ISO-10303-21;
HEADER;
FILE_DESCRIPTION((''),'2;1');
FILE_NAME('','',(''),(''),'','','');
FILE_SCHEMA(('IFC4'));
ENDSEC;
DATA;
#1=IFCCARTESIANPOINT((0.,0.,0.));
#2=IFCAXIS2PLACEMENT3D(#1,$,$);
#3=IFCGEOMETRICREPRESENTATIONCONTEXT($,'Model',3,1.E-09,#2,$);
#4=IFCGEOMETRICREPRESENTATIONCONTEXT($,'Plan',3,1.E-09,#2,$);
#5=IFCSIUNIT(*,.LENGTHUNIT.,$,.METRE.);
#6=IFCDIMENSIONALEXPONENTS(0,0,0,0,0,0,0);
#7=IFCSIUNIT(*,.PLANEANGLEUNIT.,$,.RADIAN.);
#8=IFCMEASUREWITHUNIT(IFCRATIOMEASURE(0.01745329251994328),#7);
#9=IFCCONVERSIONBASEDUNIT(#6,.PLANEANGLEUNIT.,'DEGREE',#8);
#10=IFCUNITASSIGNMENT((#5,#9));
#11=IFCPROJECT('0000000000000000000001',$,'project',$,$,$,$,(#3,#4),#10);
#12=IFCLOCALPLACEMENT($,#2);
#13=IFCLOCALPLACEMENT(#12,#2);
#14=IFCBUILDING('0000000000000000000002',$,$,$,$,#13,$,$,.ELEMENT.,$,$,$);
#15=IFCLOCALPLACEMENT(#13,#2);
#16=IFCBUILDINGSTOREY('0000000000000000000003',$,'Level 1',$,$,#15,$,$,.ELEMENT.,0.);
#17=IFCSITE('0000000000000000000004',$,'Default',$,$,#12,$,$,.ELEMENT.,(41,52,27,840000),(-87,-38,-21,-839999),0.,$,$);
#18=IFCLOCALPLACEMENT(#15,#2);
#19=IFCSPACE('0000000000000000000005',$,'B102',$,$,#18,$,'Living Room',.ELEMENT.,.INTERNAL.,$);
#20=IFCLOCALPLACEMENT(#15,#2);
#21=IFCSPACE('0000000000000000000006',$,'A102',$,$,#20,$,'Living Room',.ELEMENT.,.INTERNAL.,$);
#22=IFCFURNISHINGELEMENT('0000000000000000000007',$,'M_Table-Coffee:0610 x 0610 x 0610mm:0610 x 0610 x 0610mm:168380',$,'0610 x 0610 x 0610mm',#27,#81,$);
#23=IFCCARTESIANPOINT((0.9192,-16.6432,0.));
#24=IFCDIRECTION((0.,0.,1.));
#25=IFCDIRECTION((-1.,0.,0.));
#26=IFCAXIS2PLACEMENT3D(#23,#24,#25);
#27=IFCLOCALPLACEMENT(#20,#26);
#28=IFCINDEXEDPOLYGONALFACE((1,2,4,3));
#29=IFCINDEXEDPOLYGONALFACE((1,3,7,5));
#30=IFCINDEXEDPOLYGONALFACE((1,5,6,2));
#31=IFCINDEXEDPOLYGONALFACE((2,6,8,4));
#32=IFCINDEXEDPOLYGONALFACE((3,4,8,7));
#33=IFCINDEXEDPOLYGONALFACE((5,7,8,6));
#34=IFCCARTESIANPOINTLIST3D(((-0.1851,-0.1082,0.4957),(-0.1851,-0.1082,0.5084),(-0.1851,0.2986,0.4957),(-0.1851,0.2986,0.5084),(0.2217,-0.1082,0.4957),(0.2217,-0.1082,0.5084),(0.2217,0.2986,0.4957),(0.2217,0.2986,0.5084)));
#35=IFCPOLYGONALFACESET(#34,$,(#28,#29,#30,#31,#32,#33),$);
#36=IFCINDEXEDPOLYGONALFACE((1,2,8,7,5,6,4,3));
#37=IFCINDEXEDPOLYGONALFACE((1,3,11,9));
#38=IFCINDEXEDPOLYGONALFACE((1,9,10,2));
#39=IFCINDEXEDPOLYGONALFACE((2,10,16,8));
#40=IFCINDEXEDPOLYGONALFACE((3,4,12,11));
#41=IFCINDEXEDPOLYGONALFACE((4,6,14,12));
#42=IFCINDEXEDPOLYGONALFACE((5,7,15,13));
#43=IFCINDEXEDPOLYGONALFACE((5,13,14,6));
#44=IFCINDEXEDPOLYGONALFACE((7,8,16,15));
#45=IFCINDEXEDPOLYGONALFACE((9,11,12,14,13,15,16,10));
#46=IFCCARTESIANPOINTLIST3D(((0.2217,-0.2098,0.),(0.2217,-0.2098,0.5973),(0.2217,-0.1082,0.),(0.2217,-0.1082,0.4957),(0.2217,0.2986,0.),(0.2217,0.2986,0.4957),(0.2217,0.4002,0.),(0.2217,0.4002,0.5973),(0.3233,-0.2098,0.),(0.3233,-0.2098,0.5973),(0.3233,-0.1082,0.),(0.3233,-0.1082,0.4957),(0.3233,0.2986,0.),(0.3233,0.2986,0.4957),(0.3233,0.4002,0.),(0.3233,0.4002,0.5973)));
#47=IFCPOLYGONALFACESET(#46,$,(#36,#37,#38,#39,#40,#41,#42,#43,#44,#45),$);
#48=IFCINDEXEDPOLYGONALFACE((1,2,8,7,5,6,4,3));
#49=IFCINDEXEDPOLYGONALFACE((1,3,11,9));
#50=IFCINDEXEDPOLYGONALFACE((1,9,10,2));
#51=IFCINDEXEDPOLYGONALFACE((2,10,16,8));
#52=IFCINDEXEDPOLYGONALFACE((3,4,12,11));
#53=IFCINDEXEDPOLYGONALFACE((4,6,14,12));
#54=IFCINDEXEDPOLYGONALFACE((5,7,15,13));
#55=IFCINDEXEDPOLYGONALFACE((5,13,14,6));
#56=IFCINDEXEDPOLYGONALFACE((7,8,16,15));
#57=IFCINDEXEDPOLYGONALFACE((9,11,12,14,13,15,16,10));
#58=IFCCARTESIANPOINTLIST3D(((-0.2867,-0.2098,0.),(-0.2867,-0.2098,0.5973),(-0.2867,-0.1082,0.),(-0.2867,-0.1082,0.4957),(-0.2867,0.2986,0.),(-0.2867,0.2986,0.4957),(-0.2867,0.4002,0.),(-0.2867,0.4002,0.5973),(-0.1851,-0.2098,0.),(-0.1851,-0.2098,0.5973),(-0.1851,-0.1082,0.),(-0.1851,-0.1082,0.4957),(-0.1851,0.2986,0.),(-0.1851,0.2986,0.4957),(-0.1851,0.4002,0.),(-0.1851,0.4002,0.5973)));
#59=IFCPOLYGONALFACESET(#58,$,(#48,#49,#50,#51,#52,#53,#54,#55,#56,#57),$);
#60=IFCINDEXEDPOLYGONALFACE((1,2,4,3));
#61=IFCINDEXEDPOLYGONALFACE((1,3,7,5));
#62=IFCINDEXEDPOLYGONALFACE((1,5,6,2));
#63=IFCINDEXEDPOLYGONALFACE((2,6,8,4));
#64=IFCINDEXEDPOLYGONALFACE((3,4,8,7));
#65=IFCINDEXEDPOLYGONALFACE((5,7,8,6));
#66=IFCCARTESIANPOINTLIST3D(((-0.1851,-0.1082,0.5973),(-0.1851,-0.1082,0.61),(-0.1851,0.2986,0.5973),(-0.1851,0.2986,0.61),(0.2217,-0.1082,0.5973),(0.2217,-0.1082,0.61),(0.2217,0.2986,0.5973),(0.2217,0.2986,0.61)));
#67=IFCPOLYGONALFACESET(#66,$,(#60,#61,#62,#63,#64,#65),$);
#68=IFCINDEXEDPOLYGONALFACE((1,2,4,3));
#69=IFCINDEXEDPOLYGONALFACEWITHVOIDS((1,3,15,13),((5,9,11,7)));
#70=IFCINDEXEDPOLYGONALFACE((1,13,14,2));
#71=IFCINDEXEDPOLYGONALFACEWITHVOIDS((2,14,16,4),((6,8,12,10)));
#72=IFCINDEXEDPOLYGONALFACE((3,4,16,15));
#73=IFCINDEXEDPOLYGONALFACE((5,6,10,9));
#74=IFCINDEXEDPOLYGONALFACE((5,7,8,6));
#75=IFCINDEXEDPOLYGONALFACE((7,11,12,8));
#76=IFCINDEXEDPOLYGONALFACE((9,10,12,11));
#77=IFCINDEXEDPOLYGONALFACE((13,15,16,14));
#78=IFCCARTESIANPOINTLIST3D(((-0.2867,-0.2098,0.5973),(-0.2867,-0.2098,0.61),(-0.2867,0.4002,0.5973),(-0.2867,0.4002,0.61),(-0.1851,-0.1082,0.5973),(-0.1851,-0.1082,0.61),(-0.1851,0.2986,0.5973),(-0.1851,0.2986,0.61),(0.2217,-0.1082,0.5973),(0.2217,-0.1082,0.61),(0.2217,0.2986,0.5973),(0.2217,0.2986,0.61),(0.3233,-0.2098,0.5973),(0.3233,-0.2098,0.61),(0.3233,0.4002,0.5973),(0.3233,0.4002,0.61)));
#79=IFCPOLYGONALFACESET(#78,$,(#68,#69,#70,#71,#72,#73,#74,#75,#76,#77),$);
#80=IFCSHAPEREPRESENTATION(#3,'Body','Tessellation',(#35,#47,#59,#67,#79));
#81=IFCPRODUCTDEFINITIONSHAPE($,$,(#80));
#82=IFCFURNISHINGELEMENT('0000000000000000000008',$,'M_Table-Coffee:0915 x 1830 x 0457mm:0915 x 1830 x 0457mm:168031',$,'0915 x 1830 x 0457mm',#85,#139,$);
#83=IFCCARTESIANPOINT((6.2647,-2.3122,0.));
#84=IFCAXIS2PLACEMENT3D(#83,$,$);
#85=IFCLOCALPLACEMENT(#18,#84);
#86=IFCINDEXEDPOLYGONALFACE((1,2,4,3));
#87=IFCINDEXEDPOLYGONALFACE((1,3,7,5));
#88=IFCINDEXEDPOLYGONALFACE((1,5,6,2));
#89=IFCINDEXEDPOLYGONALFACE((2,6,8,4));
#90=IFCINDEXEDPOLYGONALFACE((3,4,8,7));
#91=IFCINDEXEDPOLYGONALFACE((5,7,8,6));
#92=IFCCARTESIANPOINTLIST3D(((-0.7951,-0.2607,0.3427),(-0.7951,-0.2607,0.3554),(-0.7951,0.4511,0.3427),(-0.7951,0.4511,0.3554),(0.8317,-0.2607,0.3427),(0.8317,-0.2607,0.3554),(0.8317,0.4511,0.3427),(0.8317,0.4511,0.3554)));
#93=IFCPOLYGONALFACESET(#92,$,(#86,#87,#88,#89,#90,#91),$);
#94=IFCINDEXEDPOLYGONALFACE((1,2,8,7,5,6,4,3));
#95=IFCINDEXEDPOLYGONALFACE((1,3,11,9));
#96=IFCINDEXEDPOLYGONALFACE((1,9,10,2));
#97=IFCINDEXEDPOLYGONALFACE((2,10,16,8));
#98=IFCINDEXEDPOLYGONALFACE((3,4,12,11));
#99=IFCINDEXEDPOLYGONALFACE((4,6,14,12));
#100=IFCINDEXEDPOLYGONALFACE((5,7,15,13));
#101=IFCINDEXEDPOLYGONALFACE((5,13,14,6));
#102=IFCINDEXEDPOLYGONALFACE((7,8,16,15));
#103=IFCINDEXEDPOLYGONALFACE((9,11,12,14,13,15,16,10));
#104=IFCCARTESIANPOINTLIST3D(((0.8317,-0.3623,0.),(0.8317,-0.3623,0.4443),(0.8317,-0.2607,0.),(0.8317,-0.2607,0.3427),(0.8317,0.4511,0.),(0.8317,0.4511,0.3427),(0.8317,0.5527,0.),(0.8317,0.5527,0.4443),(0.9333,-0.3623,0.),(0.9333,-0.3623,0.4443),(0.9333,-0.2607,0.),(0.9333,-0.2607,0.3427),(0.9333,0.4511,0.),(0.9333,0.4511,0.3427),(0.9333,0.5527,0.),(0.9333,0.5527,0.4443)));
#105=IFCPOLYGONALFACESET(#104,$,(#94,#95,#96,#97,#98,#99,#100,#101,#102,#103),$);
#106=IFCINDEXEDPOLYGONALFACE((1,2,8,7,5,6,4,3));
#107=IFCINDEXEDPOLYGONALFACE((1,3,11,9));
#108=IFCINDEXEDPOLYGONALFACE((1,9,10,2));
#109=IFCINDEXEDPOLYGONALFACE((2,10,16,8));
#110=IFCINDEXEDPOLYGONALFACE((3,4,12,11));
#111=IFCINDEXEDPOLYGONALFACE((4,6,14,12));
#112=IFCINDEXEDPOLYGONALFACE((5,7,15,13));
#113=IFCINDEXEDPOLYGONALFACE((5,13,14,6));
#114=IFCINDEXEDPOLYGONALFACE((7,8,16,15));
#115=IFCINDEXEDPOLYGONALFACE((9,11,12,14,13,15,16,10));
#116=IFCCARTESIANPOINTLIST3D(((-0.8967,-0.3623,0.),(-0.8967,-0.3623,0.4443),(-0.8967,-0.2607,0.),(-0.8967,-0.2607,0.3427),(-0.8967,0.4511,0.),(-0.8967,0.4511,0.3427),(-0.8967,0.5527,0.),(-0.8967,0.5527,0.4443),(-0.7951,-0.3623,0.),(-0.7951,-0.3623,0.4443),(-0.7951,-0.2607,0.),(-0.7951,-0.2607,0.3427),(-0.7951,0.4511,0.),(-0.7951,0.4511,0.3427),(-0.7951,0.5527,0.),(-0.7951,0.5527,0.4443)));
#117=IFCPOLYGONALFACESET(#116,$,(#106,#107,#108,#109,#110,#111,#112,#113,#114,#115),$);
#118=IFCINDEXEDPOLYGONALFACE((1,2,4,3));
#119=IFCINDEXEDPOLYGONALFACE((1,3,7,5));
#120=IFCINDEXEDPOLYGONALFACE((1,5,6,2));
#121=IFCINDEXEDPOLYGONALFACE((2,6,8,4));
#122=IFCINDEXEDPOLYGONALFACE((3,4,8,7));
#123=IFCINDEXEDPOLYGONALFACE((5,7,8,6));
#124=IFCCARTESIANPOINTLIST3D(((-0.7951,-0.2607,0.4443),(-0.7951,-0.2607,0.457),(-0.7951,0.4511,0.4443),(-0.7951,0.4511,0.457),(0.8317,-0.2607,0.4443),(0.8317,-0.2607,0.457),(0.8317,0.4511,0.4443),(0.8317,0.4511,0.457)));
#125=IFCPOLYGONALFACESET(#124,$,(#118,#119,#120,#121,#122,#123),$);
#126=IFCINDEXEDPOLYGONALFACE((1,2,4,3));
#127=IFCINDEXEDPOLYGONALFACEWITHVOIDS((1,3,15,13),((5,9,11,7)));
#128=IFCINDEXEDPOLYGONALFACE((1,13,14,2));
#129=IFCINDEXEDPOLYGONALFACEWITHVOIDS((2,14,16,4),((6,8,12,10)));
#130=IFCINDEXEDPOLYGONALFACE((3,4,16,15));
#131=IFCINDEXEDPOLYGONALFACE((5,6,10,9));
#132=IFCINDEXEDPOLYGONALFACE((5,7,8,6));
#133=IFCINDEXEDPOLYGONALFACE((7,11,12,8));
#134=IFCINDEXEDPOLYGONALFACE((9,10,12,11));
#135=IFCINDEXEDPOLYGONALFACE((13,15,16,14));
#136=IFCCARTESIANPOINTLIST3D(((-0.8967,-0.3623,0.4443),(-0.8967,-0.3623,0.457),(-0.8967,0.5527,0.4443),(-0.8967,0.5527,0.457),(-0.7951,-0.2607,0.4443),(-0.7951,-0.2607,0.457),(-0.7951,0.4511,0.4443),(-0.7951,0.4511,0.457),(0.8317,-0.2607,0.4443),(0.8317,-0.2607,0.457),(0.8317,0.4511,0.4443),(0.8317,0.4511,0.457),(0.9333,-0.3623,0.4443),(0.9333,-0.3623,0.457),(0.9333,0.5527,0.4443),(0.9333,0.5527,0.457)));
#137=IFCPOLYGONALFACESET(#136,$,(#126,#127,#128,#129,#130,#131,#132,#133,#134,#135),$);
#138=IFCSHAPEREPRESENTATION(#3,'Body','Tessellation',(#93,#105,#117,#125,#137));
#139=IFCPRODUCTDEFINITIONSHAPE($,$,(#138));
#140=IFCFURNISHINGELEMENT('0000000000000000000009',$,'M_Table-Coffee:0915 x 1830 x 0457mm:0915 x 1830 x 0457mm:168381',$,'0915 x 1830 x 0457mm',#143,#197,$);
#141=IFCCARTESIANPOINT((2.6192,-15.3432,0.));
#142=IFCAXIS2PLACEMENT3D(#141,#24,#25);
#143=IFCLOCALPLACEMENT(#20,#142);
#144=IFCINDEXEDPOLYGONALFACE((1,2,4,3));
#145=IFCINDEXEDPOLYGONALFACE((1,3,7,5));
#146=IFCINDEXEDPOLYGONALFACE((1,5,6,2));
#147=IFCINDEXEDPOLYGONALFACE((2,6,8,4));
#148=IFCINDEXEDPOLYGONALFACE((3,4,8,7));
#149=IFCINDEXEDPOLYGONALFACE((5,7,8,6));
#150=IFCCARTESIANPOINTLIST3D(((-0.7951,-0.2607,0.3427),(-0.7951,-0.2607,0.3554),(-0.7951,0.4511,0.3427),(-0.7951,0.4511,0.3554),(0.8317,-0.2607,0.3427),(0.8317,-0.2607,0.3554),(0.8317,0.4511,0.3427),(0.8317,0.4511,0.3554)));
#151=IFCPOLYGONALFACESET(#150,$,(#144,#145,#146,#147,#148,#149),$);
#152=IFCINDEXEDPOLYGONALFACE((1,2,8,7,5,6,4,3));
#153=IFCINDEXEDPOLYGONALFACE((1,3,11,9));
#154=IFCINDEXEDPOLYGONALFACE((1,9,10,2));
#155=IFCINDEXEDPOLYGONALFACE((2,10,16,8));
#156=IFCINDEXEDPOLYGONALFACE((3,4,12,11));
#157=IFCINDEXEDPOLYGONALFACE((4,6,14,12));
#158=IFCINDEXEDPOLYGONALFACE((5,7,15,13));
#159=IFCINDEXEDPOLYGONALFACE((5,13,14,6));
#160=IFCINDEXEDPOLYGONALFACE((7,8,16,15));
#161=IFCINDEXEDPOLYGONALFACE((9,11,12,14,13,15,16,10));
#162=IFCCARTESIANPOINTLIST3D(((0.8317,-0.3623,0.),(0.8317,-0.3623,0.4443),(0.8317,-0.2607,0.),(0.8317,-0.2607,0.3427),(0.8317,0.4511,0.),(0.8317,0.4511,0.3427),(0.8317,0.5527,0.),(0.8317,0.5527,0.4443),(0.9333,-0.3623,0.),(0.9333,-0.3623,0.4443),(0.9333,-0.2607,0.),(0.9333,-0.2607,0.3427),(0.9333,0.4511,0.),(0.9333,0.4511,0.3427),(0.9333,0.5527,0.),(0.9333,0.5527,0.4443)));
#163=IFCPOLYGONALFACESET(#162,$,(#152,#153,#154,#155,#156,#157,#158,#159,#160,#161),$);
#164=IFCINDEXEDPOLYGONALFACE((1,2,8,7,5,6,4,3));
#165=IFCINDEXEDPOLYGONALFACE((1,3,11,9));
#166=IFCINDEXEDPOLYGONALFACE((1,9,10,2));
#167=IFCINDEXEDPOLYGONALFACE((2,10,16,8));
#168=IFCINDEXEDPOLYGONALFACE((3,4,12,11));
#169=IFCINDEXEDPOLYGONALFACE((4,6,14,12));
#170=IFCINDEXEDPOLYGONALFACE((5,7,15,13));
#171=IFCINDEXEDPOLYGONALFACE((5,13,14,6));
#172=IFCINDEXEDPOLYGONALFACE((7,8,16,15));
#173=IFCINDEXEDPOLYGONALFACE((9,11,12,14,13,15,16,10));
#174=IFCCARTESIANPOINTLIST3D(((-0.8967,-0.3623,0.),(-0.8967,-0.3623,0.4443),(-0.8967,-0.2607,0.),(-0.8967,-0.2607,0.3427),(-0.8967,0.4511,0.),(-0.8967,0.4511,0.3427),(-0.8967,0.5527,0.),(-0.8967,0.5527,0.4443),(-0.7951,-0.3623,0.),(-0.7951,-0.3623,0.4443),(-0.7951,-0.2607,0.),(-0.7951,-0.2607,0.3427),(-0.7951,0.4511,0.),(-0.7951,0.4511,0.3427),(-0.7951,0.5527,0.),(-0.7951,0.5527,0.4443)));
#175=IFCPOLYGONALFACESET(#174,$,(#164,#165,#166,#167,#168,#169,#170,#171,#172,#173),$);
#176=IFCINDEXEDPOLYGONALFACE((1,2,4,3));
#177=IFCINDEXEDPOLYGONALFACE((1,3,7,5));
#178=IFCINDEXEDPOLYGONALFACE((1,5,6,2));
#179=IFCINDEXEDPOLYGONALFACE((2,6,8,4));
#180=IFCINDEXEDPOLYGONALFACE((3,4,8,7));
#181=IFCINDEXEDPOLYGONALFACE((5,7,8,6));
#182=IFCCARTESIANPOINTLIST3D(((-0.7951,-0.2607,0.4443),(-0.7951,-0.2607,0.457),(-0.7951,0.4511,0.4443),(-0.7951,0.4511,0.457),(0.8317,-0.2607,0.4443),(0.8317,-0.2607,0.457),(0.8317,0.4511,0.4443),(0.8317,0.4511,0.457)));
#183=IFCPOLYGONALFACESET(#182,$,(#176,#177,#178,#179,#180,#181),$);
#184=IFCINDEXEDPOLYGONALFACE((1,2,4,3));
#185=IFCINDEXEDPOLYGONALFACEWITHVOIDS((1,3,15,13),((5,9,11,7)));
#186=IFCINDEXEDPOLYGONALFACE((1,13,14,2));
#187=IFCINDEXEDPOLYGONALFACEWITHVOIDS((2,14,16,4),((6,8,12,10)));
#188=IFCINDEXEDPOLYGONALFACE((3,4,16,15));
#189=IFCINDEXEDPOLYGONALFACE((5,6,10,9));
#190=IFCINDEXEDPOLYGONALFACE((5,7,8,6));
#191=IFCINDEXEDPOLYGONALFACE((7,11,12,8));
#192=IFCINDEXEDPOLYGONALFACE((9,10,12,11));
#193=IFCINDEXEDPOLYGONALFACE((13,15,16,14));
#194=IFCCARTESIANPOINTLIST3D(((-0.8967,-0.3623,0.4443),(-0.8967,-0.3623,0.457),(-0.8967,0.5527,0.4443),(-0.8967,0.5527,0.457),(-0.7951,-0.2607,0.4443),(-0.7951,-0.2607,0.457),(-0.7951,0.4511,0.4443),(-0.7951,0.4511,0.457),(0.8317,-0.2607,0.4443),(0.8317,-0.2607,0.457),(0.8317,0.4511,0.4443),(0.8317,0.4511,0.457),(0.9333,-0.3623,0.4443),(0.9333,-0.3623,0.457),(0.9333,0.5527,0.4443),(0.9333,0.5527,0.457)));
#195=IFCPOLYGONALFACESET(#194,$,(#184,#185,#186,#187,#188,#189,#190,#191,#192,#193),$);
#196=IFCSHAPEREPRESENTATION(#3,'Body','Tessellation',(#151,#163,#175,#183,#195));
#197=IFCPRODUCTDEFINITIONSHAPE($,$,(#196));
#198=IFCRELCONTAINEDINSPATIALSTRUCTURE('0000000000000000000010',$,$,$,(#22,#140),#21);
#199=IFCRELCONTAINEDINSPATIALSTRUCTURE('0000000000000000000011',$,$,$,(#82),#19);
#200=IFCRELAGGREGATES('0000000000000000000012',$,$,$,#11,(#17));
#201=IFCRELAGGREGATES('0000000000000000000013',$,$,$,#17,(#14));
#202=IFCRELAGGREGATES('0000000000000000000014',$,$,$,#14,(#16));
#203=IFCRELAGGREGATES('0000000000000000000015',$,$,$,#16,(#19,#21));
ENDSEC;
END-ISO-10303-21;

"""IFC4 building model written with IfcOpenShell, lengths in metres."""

from ifc_helpers import new_model, entity, si_unit, converted_unit, frame, origin, origin_2d_with_axis, place, context, project, spatial, polyline, rectangle, outline, extrude, source, transform, mapped, element, save


model = new_model("IFC4")

# Units and contexts
model_context = context("Model", 3, precision=1e-09, world=origin())
plan_context = context("Plan", 3, precision=1e-09, world=origin())
ifc_project = project(units=[si_unit("LENGTHUNIT", "METRE"), converted_unit("PLANEANGLEUNIT", "DEGREE", entity("IfcRatioMeasure", 0.01745329251994328), si_unit("PLANEANGLEUNIT", "RADIAN"), dimensions=[0, 0, 0, 0, 0, 0, 0])], contexts=[model_context, plan_context])

# Site, building, storey
site_placement = place(None, origin())
site = spatial("IfcSite", under=ifc_project, at=site_placement, Name="Default", CompositionType="ELEMENT", RefLatitude=(41, 52, 27, 840000), RefLongitude=(-87, -38, -21, -839999), RefElevation=0.0)
building_placement = place(site_placement, origin())
building = spatial("IfcBuilding", under=site, at=building_placement, CompositionType="ELEMENT")
storey_placement = place(building_placement, origin())
storey = spatial("IfcBuildingStorey", under=building, at=storey_placement, Name="Level 1", CompositionType="ELEMENT", Elevation=0.0)

# Shared definitions
space_1_placement = place(storey_placement, origin())
space_1 = spatial("IfcSpace", under=storey, at=space_1_placement, Name="B102", LongName="Living Room", CompositionType="ELEMENT", PredefinedType="INTERNAL")

# Shared definitions
shared_shape_1 = source(origin(), model_context, "Body", "SweptSolid", [
    extrude(rectangle(XDim=0.4068, YDim=0.4068, at=origin_2d_with_axis()), frame((0.0183, 0.0952, 0.4957), z_axis=(0.0, 0.0, 1.0), x_axis=(-1.0, 0.0, 0.0)), (0.0, 0.0, 1.0), 0.0127),
    extrude(outline(polyline([(-0.2732, -0.305), (0.324, -0.305), (0.324, 0.305), (-0.2732, 0.305), (-0.2732, 0.2034), (0.2225, 0.2034), (0.2225, -0.2034), (-0.2732, -0.2034), (-0.2732, -0.305)])), frame((0.2217, 0.0952, 0.2732), z_axis=(1.0, 0.0, 0.0), x_axis=(0.0, 0.0, 1.0)), (0.0, 0.0, 1.0), 0.1016),
    extrude(outline(polyline([(-0.305, -0.3241), (0.305, -0.3241), (0.305, 0.2733), (0.2034, 0.2733), (0.2034, -0.2224), (-0.2034, -0.2224), (-0.2034, 0.2733), (-0.305, 0.2733), (-0.305, -0.3241)])), frame((-0.2867, 0.0952, 0.2733), z_axis=(1.0, 0.0, 0.0), x_axis=(0.0, -1.0, 0.0)), (0.0, 0.0, 1.0), 0.1016),
    extrude(rectangle(XDim=0.4068, YDim=0.4068, at=origin_2d_with_axis()), frame((0.0183, 0.0952, 0.5973), z_axis=(0.0, 0.0, 1.0), x_axis=(-1.0, 0.0, 0.0)), (0.0, 0.0, 1.0), 0.0127),
    extrude(outline(polyline([(-0.305, -0.305), (0.305, -0.305), (0.305, 0.305), (-0.305, 0.305), (-0.305, -0.305)]), holes=[polyline([(-0.2034, -0.2034), (-0.2034, 0.2034), (0.2034, 0.2034), (0.2034, -0.2034), (-0.2034, -0.2034)])]), frame((0.0183, 0.0952, 0.5973), z_axis=(0.0, 0.0, 1.0), x_axis=(-1.0, 0.0, 0.0)), (0.0, 0.0, 1.0), 0.0127),
])

# Shared definitions
space_2_placement = place(storey_placement, origin())
space_2 = spatial("IfcSpace", under=storey, at=space_2_placement, Name="A102", LongName="Living Room", CompositionType="ELEMENT", PredefinedType="INTERNAL")

# Furnishing elements
for number, where, z_axis, x_axis, name in (
    (1, (0.9192, -16.6432, 0.0), (0.0, 0.0, 1.0), (-1.0, 0.0, 0.0), "M_Table-Coffee:0610 x 0610 x 0610mm:0610 x 0610 x 0610mm:168380"),
):
    element("IfcFurnishingElement", number, at=place(space_2_placement, frame(where, z_axis=z_axis, x_axis=x_axis)), inside=space_2, Name=name, ObjectType="0610 x 0610 x 0610mm", context=model_context, shape_type="MappedRepresentation", body=[
        mapped(shared_shape_1, transform((0.0, 0.0, 0.0), scale=1.0)),
    ])
shared_shape_2 = source(origin(), model_context, "Body", "SweptSolid", [
    extrude(rectangle(XDim=1.6268, YDim=0.7118, at=origin_2d_with_axis()), frame((0.0183, 0.0952, 0.3427), z_axis=(0.0, 0.0, 1.0), x_axis=(-1.0, 0.0, 0.0)), (0.0, 0.0, 1.0), 0.0127),
    extrude(outline(polyline([(-0.1967, -0.4575), (0.2475, -0.4575), (0.2475, 0.4575), (-0.1967, 0.4575), (-0.1967, 0.3559), (0.146, 0.3559), (0.146, -0.3559), (-0.1967, -0.3559), (-0.1967, -0.4575)])), frame((0.8317, 0.0952, 0.1967), z_axis=(1.0, 0.0, 0.0), x_axis=(0.0, 0.0, 1.0)), (0.0, 0.0, 1.0), 0.1016),
    extrude(outline(polyline([(-0.4575, -0.2476), (0.4575, -0.2476), (0.4575, 0.1968), (0.3559, 0.1968), (0.3559, -0.1459), (-0.3559, -0.1459), (-0.3559, 0.1968), (-0.4575, 0.1968), (-0.4575, -0.2476)])), frame((-0.8967, 0.0952, 0.1968), z_axis=(1.0, 0.0, 0.0), x_axis=(0.0, -1.0, 0.0)), (0.0, 0.0, 1.0), 0.1016),
    extrude(rectangle(XDim=1.6268, YDim=0.7118, at=origin_2d_with_axis()), frame((0.0183, 0.0952, 0.4443), z_axis=(0.0, 0.0, 1.0), x_axis=(-1.0, 0.0, 0.0)), (0.0, 0.0, 1.0), 0.0127),
    extrude(outline(polyline([(-0.915, -0.4575), (0.915, -0.4575), (0.915, 0.4575), (-0.915, 0.4575), (-0.915, -0.4575)]), holes=[polyline([(-0.8134, -0.3559), (-0.8134, 0.3559), (0.8134, 0.3559), (0.8134, -0.3559), (-0.8134, -0.3559)])]), frame((0.0183, 0.0952, 0.4443), z_axis=(0.0, 0.0, 1.0), x_axis=(-1.0, 0.0, 0.0)), (0.0, 0.0, 1.0), 0.0127),
])
furnishing_1_placement = place(space_1_placement, frame((6.2647, -2.3122, 0.0)))
element("IfcFurnishingElement", 2, at=furnishing_1_placement, inside=space_1, Name="M_Table-Coffee:0915 x 1830 x 0457mm:0915 x 1830 x 0457mm:168031", ObjectType="0915 x 1830 x 0457mm", context=model_context, shape_type="MappedRepresentation", body=[
    mapped(shared_shape_2, transform((0.0, 0.0, 0.0), scale=1.0)),
])
furnishing_2_placement = place(space_2_placement, frame((2.6192, -15.3432, 0.0), z_axis=(0.0, 0.0, 1.0), x_axis=(-1.0, 0.0, 0.0)))
element("IfcFurnishingElement", 3, at=furnishing_2_placement, inside=space_2, Name="M_Table-Coffee:0915 x 1830 x 0457mm:0915 x 1830 x 0457mm:168381", ObjectType="0915 x 1830 x 0457mm", context=model_context, shape_type="MappedRepresentation", body=[
    mapped(shared_shape_2, transform((0.0, 0.0, 0.0), scale=1.0)),
])

save(model, "model.ifc")
